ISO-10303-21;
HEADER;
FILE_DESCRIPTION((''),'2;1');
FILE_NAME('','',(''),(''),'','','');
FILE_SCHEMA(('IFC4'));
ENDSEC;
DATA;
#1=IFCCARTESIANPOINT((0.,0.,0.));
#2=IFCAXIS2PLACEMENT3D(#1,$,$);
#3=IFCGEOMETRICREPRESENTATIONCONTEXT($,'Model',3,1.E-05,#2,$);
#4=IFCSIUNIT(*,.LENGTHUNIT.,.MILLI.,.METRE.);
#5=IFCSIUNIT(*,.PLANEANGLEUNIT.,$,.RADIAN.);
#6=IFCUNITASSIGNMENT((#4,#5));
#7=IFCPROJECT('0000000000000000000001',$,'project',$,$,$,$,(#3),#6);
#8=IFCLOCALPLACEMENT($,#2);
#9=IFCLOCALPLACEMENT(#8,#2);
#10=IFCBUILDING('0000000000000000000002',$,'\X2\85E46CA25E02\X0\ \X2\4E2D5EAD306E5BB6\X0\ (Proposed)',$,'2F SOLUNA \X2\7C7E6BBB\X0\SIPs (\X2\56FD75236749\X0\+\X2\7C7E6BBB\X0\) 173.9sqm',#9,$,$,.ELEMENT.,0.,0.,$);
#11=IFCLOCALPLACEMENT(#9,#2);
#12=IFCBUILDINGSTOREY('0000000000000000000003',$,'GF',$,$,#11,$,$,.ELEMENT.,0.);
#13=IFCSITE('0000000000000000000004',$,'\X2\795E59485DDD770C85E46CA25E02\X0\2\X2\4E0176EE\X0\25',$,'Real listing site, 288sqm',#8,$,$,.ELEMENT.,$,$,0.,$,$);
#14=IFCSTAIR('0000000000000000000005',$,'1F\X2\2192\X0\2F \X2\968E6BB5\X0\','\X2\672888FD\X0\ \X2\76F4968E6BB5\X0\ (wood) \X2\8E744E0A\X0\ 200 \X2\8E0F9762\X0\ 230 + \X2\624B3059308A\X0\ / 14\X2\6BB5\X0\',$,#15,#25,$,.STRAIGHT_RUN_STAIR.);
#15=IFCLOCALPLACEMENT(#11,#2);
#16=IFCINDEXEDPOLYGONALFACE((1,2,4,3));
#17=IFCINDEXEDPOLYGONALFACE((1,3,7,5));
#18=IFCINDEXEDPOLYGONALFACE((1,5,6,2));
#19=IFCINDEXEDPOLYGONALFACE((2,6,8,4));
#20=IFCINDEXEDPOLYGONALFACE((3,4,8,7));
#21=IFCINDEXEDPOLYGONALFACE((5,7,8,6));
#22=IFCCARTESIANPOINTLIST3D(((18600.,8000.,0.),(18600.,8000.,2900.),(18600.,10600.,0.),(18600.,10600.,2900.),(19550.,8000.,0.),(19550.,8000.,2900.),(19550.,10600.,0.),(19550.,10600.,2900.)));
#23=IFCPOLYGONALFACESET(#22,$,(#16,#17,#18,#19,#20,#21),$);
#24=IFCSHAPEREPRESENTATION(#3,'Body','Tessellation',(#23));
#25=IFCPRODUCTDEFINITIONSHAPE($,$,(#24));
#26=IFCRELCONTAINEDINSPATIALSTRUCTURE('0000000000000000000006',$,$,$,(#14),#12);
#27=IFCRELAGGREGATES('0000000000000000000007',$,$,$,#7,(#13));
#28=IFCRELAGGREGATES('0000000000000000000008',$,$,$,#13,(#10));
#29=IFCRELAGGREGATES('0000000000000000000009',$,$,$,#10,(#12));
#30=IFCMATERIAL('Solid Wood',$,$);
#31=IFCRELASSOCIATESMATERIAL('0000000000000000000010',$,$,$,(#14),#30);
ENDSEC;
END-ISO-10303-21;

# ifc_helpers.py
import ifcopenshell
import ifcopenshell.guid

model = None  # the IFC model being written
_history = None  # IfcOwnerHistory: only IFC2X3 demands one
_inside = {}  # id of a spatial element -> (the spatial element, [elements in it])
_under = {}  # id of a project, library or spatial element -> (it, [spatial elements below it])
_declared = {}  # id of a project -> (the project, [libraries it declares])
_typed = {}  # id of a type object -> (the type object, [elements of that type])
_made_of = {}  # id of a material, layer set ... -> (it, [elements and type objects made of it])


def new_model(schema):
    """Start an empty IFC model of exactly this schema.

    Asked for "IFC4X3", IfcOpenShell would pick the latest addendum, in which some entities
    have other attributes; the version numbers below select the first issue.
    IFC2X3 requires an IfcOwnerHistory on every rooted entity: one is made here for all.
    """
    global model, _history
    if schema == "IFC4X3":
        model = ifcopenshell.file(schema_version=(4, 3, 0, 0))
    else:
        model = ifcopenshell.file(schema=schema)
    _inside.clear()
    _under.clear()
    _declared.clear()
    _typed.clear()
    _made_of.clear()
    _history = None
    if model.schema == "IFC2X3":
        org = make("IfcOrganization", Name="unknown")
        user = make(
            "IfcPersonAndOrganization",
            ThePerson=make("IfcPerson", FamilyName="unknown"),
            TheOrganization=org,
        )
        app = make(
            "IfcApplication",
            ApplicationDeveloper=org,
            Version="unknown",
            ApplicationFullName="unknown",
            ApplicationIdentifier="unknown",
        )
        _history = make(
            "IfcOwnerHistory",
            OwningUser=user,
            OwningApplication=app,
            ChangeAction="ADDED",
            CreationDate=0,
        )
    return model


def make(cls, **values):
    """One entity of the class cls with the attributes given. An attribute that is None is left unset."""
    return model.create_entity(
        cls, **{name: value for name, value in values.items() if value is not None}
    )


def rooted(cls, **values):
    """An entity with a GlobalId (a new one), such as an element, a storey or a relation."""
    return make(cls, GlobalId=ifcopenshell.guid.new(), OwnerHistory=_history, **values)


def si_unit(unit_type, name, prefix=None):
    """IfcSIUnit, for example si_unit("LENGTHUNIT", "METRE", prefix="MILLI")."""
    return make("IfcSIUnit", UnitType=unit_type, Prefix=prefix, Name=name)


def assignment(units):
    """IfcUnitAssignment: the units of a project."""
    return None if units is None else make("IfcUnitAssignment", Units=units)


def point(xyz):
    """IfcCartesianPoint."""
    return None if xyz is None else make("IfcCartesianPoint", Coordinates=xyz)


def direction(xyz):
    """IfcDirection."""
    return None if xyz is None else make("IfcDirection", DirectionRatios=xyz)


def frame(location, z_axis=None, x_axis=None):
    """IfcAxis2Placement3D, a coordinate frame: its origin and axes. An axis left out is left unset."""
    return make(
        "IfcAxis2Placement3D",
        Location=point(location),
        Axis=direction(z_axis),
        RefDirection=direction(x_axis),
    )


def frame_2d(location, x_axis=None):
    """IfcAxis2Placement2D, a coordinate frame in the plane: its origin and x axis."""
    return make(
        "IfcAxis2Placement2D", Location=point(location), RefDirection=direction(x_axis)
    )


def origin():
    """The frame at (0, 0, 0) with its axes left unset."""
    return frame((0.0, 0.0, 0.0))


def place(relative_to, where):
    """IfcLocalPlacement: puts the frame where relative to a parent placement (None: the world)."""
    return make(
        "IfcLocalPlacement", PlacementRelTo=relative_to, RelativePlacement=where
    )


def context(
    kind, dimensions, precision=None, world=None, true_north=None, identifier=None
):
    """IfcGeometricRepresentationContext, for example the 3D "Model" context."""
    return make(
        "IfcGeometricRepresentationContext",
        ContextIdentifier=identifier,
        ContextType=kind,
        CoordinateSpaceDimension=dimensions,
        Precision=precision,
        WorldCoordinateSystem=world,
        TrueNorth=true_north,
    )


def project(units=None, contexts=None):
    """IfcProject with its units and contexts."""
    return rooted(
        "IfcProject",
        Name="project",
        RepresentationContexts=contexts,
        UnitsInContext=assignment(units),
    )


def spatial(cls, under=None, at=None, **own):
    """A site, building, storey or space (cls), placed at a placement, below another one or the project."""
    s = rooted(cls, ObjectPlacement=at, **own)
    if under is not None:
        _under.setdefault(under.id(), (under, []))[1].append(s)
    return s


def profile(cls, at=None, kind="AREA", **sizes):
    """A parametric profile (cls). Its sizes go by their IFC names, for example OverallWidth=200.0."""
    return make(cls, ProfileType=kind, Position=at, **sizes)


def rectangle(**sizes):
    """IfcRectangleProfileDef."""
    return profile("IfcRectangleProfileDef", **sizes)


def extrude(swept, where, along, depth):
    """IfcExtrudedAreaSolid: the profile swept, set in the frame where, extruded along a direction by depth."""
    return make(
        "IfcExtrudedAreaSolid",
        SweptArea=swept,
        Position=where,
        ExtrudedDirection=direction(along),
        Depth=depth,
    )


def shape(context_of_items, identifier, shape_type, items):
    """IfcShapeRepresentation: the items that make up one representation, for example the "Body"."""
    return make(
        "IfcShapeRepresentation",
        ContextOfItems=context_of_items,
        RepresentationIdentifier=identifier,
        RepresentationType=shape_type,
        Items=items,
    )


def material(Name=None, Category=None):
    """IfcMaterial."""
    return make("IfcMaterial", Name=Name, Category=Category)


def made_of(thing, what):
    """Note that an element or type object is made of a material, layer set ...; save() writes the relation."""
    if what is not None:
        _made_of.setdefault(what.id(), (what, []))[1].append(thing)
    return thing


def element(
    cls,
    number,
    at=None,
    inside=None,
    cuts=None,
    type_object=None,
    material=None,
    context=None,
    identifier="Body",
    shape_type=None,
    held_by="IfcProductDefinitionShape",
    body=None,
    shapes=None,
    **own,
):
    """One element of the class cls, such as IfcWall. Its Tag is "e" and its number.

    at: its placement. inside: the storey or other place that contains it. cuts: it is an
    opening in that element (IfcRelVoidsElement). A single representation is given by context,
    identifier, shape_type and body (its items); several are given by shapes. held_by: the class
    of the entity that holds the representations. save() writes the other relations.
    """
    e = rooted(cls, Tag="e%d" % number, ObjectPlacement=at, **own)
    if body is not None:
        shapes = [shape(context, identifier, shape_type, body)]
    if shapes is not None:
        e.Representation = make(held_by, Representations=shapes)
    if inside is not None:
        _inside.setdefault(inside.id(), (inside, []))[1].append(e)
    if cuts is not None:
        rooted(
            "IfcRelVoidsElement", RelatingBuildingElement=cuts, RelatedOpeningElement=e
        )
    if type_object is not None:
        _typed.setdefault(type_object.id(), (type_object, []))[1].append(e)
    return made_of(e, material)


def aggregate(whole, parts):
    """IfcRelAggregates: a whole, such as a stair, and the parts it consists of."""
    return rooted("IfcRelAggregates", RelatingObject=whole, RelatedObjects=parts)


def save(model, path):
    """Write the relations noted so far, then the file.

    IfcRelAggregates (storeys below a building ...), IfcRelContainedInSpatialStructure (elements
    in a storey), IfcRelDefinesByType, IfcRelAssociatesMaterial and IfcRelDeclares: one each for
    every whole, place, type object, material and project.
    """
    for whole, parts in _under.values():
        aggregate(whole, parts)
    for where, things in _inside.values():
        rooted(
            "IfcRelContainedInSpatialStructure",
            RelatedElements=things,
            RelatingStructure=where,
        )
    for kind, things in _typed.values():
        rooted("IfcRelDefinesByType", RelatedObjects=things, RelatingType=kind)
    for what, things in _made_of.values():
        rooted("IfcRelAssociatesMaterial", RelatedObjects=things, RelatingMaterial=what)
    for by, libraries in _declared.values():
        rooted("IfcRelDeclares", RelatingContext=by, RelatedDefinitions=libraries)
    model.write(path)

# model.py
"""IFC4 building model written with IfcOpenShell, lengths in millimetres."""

from ifc_helpers import new_model, si_unit, frame, frame_2d, origin, place, context, project, spatial, rectangle, extrude, material, element, save


model = new_model("IFC4")

# Units and contexts
model_context = context("Model", 3, precision=1e-05, world=origin())
ifc_project = project(units=[si_unit("LENGTHUNIT", "METRE", prefix="MILLI"), si_unit("PLANEANGLEUNIT", "RADIAN")], contexts=[model_context])

# Site, building, storey
site_placement = place(None, origin())
site = spatial("IfcSite", under=ifc_project, at=site_placement, Name="神奈川県藤沢市2丁目25", ObjectType="Real listing site, 288sqm", CompositionType="ELEMENT", RefElevation=0.0)
building_placement = place(site_placement, origin())
building = spatial("IfcBuilding", under=site, at=building_placement, Name="藤沢市 中庭の家 (Proposed)", ObjectType="2F SOLUNA 籾殻SIPs (国産杉+籾殻) 173.9sqm", CompositionType="ELEMENT", ElevationOfRefHeight=0.0, ElevationOfTerrain=0.0)
storey_placement = place(building_placement, origin())
storey = spatial("IfcBuildingStorey", under=building, at=storey_placement, Name="GF", CompositionType="ELEMENT", Elevation=0.0)

# Shared definitions
ifc_material_1 = material(Name="Solid Wood")

# Stair
stair_placement = place(storey_placement, frame((9300.0, 4000.0, 0.0)))
element("IfcStair", 1, at=stair_placement, inside=storey, material=ifc_material_1, Name="1F→2F 階段", Description="木製 直階段 (wood) 蹴上 200 踏面 230 + 手すり / 14段", PredefinedType="STRAIGHT_RUN_STAIR", context=model_context, shape_type="SweptSolid", body=[
    extrude(rectangle(XDim=950.0, YDim=2600.0, at=frame_2d((475.0, 1300.0))), frame((9300.0, 4000.0, 0.0)), (0.0, 0.0, 1.0), 2900.0),
])

save(model, "model.ifc")
